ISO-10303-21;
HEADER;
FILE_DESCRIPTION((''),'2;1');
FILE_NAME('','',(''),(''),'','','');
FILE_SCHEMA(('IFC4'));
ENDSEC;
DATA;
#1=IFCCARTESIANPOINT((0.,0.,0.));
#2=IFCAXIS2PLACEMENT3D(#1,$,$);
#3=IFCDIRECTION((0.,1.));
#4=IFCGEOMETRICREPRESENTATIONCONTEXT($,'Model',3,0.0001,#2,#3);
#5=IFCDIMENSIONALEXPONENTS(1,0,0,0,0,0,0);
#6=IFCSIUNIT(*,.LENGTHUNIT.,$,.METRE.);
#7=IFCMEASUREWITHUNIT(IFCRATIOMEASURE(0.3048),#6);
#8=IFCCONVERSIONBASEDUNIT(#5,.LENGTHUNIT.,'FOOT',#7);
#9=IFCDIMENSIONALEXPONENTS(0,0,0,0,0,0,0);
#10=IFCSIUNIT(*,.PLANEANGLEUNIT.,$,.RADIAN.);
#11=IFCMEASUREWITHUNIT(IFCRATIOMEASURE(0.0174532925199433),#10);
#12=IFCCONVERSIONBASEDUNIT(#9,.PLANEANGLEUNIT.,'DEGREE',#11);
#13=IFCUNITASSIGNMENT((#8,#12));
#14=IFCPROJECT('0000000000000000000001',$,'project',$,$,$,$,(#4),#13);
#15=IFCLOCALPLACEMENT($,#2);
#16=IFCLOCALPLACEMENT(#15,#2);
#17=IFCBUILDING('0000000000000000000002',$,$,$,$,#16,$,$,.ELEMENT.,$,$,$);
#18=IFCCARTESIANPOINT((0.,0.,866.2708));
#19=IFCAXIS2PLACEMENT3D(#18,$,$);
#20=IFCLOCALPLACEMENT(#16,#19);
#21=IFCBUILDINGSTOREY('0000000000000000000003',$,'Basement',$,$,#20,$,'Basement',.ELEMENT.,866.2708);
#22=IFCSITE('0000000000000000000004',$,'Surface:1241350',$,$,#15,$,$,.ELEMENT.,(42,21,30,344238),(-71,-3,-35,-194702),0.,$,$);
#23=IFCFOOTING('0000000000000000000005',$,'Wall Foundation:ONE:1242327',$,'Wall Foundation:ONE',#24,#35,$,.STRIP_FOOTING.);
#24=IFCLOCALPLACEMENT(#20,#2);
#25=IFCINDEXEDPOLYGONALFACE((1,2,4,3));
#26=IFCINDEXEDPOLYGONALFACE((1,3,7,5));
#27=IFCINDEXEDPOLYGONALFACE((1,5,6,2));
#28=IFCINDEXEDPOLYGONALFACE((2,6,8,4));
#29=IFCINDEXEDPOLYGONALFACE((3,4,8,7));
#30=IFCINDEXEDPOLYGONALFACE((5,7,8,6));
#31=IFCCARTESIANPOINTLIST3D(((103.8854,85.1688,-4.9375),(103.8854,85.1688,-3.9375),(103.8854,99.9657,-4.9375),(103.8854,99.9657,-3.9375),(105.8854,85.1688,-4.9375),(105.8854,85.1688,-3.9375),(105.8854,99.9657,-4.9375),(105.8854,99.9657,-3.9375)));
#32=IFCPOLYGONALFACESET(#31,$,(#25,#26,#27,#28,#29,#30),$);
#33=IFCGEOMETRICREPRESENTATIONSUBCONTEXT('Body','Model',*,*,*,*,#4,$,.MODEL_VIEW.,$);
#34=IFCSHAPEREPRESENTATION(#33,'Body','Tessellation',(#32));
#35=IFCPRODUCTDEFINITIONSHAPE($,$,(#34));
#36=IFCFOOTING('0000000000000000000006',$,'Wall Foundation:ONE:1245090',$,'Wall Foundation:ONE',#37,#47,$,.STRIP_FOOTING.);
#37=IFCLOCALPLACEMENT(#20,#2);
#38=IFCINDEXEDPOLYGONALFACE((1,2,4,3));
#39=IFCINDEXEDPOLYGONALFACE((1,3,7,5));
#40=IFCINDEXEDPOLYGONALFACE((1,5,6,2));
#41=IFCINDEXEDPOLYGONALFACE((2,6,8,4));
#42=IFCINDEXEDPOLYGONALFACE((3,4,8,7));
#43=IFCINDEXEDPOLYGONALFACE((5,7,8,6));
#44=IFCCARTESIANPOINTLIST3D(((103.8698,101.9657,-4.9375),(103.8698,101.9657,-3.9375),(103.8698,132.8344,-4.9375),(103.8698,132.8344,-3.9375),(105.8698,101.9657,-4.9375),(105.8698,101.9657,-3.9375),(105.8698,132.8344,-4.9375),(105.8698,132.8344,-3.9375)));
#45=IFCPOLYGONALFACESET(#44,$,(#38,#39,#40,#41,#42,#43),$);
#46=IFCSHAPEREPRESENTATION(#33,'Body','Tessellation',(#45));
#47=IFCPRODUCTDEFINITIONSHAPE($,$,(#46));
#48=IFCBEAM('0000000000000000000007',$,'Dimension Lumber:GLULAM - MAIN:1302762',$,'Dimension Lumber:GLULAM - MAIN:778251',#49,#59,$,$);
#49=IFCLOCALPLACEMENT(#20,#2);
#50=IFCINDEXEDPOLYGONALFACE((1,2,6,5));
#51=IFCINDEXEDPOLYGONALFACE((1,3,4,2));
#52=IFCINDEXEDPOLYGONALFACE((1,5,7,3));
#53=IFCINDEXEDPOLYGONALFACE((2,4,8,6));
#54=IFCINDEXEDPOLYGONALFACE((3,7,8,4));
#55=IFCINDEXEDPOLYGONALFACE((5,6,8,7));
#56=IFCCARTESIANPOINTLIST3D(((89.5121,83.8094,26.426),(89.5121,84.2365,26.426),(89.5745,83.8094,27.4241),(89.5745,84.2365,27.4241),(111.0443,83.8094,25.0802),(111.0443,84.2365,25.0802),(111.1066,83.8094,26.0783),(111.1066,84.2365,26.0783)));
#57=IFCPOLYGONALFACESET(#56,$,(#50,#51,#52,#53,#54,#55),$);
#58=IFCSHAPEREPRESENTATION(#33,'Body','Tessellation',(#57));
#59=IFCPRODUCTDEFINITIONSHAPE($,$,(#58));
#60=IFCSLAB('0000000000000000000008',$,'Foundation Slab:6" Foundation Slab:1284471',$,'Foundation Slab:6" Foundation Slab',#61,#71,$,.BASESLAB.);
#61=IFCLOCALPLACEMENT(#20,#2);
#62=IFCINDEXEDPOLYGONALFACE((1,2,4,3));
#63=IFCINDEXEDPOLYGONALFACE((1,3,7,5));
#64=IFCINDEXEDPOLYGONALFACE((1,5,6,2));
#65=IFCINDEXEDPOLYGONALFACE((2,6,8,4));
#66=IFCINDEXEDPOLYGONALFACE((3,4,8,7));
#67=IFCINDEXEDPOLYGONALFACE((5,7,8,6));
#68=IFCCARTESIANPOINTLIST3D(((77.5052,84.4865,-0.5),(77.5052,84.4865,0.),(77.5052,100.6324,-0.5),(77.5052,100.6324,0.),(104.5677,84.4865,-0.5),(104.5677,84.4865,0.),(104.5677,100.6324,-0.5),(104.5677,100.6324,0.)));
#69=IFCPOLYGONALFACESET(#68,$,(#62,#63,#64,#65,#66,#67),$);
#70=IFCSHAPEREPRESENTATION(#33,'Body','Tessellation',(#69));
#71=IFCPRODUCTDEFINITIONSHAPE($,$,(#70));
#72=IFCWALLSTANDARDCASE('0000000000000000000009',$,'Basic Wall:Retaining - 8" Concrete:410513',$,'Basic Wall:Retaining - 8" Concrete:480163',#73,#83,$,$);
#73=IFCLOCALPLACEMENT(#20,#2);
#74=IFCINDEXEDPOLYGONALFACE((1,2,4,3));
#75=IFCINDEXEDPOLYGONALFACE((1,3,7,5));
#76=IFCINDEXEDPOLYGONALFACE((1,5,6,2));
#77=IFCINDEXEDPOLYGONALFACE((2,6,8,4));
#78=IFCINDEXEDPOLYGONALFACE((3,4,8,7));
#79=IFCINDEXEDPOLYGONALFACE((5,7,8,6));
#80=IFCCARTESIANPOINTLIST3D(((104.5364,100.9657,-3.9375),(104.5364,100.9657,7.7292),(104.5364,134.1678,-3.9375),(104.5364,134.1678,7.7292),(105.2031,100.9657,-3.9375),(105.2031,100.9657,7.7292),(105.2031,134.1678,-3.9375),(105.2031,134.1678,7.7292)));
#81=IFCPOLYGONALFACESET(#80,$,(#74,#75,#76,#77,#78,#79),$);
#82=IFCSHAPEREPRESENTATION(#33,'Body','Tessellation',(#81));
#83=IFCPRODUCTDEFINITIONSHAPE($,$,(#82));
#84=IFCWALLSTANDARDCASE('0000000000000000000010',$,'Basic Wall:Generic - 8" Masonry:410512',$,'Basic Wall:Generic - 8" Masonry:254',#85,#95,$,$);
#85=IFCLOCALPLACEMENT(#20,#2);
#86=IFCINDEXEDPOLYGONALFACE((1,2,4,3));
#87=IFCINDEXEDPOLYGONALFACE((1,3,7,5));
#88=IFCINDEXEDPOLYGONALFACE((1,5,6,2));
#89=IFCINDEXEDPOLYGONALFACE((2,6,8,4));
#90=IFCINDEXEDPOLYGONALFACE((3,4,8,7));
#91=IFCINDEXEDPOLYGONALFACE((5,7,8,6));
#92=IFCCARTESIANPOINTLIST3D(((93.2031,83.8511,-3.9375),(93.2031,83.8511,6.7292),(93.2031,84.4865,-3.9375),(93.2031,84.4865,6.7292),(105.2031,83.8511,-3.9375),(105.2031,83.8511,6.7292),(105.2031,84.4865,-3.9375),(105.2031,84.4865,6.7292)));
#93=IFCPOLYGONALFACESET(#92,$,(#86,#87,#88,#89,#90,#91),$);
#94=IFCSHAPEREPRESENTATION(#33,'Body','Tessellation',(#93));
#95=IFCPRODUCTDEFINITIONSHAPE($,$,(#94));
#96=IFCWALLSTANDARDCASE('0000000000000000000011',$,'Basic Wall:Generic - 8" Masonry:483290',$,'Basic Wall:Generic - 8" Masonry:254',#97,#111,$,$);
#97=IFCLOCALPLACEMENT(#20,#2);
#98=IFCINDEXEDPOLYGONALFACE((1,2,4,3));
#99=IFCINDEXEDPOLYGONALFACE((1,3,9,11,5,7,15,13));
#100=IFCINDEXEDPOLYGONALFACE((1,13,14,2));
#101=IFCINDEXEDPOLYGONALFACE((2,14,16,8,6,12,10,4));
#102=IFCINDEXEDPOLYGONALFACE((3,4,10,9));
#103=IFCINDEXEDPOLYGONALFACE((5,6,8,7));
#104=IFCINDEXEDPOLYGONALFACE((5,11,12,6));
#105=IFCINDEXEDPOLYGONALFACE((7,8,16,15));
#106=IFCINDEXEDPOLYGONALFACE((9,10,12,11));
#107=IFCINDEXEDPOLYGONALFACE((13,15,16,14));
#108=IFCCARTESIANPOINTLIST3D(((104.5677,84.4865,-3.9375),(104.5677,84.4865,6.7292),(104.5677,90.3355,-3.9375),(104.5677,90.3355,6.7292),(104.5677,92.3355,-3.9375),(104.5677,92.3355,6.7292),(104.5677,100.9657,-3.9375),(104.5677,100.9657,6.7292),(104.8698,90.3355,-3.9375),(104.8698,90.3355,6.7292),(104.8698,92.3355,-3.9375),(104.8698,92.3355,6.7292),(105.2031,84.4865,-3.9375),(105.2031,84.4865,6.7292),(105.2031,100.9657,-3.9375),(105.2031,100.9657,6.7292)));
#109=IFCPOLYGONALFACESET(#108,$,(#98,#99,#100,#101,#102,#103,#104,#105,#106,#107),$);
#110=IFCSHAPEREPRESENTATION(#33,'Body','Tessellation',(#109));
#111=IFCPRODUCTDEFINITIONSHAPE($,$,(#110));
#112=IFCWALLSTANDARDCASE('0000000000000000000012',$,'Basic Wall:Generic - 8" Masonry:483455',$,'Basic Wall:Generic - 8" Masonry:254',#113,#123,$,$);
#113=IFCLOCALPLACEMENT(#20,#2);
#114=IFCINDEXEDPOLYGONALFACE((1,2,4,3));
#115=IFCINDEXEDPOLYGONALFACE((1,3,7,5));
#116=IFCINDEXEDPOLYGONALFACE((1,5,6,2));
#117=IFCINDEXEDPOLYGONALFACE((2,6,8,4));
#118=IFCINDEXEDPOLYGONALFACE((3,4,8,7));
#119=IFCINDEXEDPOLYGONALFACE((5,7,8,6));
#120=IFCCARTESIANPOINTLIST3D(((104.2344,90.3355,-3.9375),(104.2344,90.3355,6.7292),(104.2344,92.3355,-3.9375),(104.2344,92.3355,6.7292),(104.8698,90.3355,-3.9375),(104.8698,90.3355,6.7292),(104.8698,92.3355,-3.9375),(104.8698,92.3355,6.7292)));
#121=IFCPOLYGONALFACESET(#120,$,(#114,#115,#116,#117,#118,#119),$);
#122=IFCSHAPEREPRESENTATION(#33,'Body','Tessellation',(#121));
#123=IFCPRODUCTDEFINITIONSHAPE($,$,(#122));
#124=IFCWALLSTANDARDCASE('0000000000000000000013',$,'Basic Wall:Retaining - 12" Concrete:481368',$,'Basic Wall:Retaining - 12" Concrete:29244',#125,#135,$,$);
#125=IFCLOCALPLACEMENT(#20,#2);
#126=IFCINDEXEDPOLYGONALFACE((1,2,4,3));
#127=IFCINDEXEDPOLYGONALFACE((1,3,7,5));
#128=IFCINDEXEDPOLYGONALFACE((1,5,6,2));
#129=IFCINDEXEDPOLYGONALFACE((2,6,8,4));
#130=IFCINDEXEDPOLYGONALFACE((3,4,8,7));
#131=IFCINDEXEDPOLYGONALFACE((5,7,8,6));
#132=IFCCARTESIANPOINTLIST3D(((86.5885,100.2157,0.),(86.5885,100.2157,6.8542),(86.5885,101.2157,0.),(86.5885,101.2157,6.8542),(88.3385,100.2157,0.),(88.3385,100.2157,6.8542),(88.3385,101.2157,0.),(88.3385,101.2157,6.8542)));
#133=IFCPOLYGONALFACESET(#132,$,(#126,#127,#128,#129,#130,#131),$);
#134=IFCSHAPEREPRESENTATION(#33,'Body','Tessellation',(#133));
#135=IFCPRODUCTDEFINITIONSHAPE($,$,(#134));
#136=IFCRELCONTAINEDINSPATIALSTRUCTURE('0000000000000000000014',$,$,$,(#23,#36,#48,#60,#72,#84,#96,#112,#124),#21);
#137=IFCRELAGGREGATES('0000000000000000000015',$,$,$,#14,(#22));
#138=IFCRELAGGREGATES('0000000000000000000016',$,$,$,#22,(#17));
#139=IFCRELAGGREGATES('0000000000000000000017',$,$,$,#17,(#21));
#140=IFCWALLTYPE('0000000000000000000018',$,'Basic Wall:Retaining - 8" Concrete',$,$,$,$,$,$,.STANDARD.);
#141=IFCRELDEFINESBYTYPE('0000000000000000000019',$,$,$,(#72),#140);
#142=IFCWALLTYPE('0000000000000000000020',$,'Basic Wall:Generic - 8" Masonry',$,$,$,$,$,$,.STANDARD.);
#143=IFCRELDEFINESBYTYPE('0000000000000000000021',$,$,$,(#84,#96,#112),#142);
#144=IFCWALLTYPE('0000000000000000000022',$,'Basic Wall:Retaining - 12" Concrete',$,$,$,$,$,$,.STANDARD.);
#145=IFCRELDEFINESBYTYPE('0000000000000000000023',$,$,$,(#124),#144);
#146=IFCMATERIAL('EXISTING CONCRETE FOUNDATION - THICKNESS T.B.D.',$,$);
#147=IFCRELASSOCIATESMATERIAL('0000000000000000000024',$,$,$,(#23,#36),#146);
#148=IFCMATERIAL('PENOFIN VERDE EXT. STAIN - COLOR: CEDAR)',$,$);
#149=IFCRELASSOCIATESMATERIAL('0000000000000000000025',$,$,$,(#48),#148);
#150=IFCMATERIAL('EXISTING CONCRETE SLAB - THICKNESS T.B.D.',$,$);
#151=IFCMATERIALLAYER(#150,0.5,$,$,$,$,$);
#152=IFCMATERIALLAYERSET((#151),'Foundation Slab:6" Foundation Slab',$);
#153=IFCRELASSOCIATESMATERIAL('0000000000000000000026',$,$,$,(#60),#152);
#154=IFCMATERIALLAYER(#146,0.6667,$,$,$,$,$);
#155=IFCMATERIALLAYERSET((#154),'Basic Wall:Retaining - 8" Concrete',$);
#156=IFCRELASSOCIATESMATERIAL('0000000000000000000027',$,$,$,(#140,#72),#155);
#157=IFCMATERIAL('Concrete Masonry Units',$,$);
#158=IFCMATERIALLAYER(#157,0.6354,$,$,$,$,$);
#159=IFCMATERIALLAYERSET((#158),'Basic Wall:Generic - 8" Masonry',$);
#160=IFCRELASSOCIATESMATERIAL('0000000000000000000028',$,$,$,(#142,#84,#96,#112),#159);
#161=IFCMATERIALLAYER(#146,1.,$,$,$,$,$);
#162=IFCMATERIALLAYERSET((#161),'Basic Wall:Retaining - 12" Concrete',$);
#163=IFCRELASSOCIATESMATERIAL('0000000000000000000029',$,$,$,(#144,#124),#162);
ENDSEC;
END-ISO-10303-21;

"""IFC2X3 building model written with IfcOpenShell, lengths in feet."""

from ifc_helpers import new_model, entity, si_unit, converted_unit, direction, frame, frame_2d, origin, place, context, subcontext, project, spatial, polyline, rectangle, extrude, clip, bounded_halfspace, material, layer, layer_set, layer_usage, type_object, element, save


model = new_model("IFC2X3")

# Units and contexts
model_context = context("Model", 3, precision=0.0001, world=origin(), true_north=direction((0.0, 1.0)))
body_context = subcontext(model_context, "Body", "Model", "MODEL_VIEW")
ifc_project = project(units=[converted_unit("LENGTHUNIT", "FOOT", entity("IfcRatioMeasure", 0.3048), si_unit("LENGTHUNIT", "METRE"), dimensions=[1, 0, 0, 0, 0, 0, 0]), converted_unit("PLANEANGLEUNIT", "DEGREE", entity("IfcRatioMeasure", 0.0174532925199433), si_unit("PLANEANGLEUNIT", "RADIAN"), dimensions=[0, 0, 0, 0, 0, 0, 0])], contexts=[model_context])

# Site, building, storey
site_placement = place(None, origin())
site = spatial("IfcSite", under=ifc_project, at=site_placement, Name="Surface:1241350", CompositionType="ELEMENT", RefLatitude=(42, 21, 30, 344238), RefLongitude=(-71, -3, -35, -194702), RefElevation=0.0)
building_placement = place(site_placement, origin())
building = spatial("IfcBuilding", under=site, at=building_placement, CompositionType="ELEMENT")
storey_placement = place(building_placement, frame((0.0, 0.0, 866.2708)))
storey = spatial("IfcBuildingStorey", under=building, at=storey_placement, Name="Basement", LongName="Basement", CompositionType="ELEMENT", Elevation=866.2708)

# Footings
ifc_material_1 = material(Name="EXISTING CONCRETE FOUNDATION - THICKNESS T.B.D.")
footing_1_placement = place(storey_placement, origin())
element("IfcFooting", 1, at=footing_1_placement, inside=storey, material=ifc_material_1, Name="Wall Foundation:ONE:1242327", ObjectType="Wall Foundation:ONE", PredefinedType="STRIP_FOOTING", context=body_context, shape_type="SweptSolid", body=[
    extrude(rectangle(XDim=14.7969, YDim=2.0, at=frame_2d((0.0, 0.0), x_axis=(1.0, 0.0))), frame((104.8854, 92.5672, -4.9375), z_axis=(0.0, 0.0, 1.0), x_axis=(0.0, -1.0, 0.0)), (0.0, 0.0, 1.0), 1.0),
])
footing_2_placement = place(storey_placement, origin())
element("IfcFooting", 2, at=footing_2_placement, inside=storey, material=ifc_material_1, Name="Wall Foundation:ONE:1245090", ObjectType="Wall Foundation:ONE", PredefinedType="STRIP_FOOTING", context=body_context, shape_type="SweptSolid", body=[
    extrude(rectangle(XDim=30.8688, YDim=2.0, at=frame_2d((0.0, 0.0), x_axis=(1.0, 0.0))), frame((104.8698, 117.4001, -4.9375), z_axis=(0.0, 0.0, 1.0), x_axis=(0.0, 1.0, 0.0)), (0.0, 0.0, 1.0), 1.0),
])

# Beam
ifc_material_2 = material(Name="PENOFIN VERDE EXT. STAIN - COLOR: CEDAR)")
beam_1_placement = place(storey_placement, frame((89.5745, 84.023, 27.4241), z_axis=(0.062378, 0.0, 0.998053), x_axis=(0.998053, 0.0, -0.062378)))
element("IfcBeam", 3, at=beam_1_placement, inside=storey, material=ifc_material_2, Name="Dimension Lumber:GLULAM - MAIN:1302762", ObjectType="Dimension Lumber:GLULAM - MAIN:778251", context=body_context, shape_type="SweptSolid", body=[
    extrude(rectangle(XDim=1.0, YDim=0.4271, at=frame_2d((0.0, 0.0), x_axis=(1.0, 0.0))), frame((0.0, 0.0, -0.5), z_axis=(1.0, 0.0, 0.0), x_axis=(0.0, 0.0, -1.0)), (0.0, 0.0, 1.0), 21.5741),
])

# Slab
ifc_material_3 = material(Name="EXISTING CONCRETE SLAB - THICKNESS T.B.D.")
ifc_layer_1 = layer(ifc_material_3, 0.5)
ifc_layer_set_1 = layer_set([ifc_layer_1], Name="Foundation Slab:6\" Foundation Slab")
ifc_layer_usage_1 = layer_usage(ifc_layer_set_1, "AXIS3", "POSITIVE", 0.0)
slab_placement = place(storey_placement, origin())
element("IfcSlab", 4, at=slab_placement, inside=storey, material=ifc_layer_usage_1, Name="Foundation Slab:6\" Foundation Slab:1284471", ObjectType="Foundation Slab:6\" Foundation Slab", PredefinedType="BASESLAB", context=body_context, shape_type="SweptSolid", body=[
    extrude(rectangle(XDim=16.1458, YDim=27.0625, at=frame_2d((0.0, 0.0), x_axis=(1.0, 0.0))), frame((91.0364, 92.5594, 0.0), z_axis=(0.0, 0.0, -1.0), x_axis=(0.0, 1.0, 0.0)), (0.0, 0.0, 1.0), 0.5),
])

# Shared definitions
ifc_layer_2 = layer(ifc_material_1, 0.6667)
ifc_layer_set_2 = layer_set([ifc_layer_2], Name="Basic Wall:Retaining - 8\" Concrete")
wall_type_1 = type_object("IfcWallType", Name="Basic Wall:Retaining - 8\" Concrete", PredefinedType="STANDARD", material=ifc_layer_set_2)

# Walls
ifc_layer_usage_2 = layer_usage(ifc_layer_set_2, "AXIS2", "NEGATIVE", 0.3333)
wall_1_placement = place(storey_placement, frame((104.8698, 134.3136, -3.9375), z_axis=(0.0, 0.0, 1.0), x_axis=(0.0, -1.0, 0.0)))
element("IfcWallStandardCase", 5, at=wall_1_placement, inside=storey, type_object=wall_type_1, material=ifc_layer_usage_2, Name="Basic Wall:Retaining - 8\" Concrete:410513", ObjectType="Basic Wall:Retaining - 8\" Concrete:480163", context=body_context, shape_type="SweptSolid", body=[
    extrude(rectangle(XDim=33.2021, YDim=0.6667, at=frame_2d((16.7469, 0.0), x_axis=(-1.0, 0.0))), origin(), (0.0, 0.0, 1.0), 11.6667),
])
ifc_material_4 = material(Name="Concrete Masonry Units")
ifc_layer_3 = layer(ifc_material_4, 0.6354)
ifc_layer_set_3 = layer_set([ifc_layer_3], Name="Basic Wall:Generic - 8\" Masonry")
ifc_layer_usage_3 = layer_usage(ifc_layer_set_3, "AXIS2", "NEGATIVE", 0.3177)
wall_type_2 = type_object("IfcWallType", Name="Basic Wall:Generic - 8\" Masonry", PredefinedType="STANDARD", material=ifc_layer_set_3)
wall_2_placement = place(storey_placement, frame((105.2031, 84.1688, -3.9375), z_axis=(0.0, 0.0, 1.0), x_axis=(-1.0, 0.0, 0.0)))
element("IfcWallStandardCase", 6, at=wall_2_placement, inside=storey, type_object=wall_type_2, material=ifc_layer_usage_3, Name="Basic Wall:Generic - 8\" Masonry:410512", ObjectType="Basic Wall:Generic - 8\" Masonry:254", context=body_context, shape_type="SweptSolid", body=[
    extrude(rectangle(XDim=12.0, YDim=0.6354, at=frame_2d((6.0, 0.0), x_axis=(-1.0, 0.0))), origin(), (0.0, 0.0, 1.0), 10.6667),
])
ifc_layer_usage_4 = layer_usage(ifc_layer_set_3, "AXIS2", "NEGATIVE", 0.3177)
wall_3_placement = place(storey_placement, frame((104.8854, 100.9657, -3.9375), z_axis=(0.0, 0.0, 1.0), x_axis=(0.0, -1.0, 0.0)))
element("IfcWallStandardCase", 7, at=wall_3_placement, inside=storey, type_object=wall_type_2, material=ifc_layer_usage_4, Name="Basic Wall:Generic - 8\" Masonry:483290", ObjectType="Basic Wall:Generic - 8\" Masonry:254", context=body_context, shape_type="Clipping", body=[
    clip(extrude(rectangle(XDim=16.4792, YDim=0.6354, at=frame_2d((8.2396, 0.0), x_axis=(-1.0, 0.0))), origin(), (0.0, 0.0, 1.0), 10.6667), bounded_halfspace(frame((8.6302, -0.0156, 10.6667), z_axis=(0.0, 1.0, 0.0), x_axis=(-1.0, 0.0, 0.0)), True, frame((8.6302, -0.0156, 10.6667), z_axis=(0.0, 1.0, 0.0), x_axis=(-1.0, 0.0, 0.0)), polyline([(0.0, 0.0), (-2.0, 0.0), (-2.0, -10.6667), (0.0, -10.6667), (0.0, 0.0)]))),
])
ifc_layer_usage_5 = layer_usage(ifc_layer_set_3, "AXIS2", "NEGATIVE", 0.3177)
wall_4_placement = place(storey_placement, frame((104.5521, 92.3355, -3.9375), z_axis=(0.0, 0.0, 1.0), x_axis=(0.0, -1.0, 0.0)))
element("IfcWallStandardCase", 8, at=wall_4_placement, inside=storey, type_object=wall_type_2, material=ifc_layer_usage_5, Name="Basic Wall:Generic - 8\" Masonry:483455", ObjectType="Basic Wall:Generic - 8\" Masonry:254", context=body_context, shape_type="SweptSolid", body=[
    extrude(rectangle(XDim=2.0, YDim=0.6354, at=frame_2d((1.0, 0.0), x_axis=(-1.0, 0.0))), origin(), (0.0, 0.0, 1.0), 10.6667),
])
ifc_layer_4 = layer(ifc_material_1, 1.0)
ifc_layer_set_4 = layer_set([ifc_layer_4], Name="Basic Wall:Retaining - 12\" Concrete")
ifc_layer_usage_6 = layer_usage(ifc_layer_set_4, "AXIS2", "POSITIVE", -0.5)
wall_type_3 = type_object("IfcWallType", Name="Basic Wall:Retaining - 12\" Concrete", PredefinedType="STANDARD", material=ifc_layer_set_4)
wall_5_placement = place(storey_placement, frame((88.3385, 100.7157, 0.0), z_axis=(0.0, 0.0, 1.0), x_axis=(-1.0, 0.0, 0.0)))
element("IfcWallStandardCase", 9, at=wall_5_placement, inside=storey, type_object=wall_type_3, material=ifc_layer_usage_6, Name="Basic Wall:Retaining - 12\" Concrete:481368", ObjectType="Basic Wall:Retaining - 12\" Concrete:29244", context=body_context, shape_type="SweptSolid", body=[
    extrude(rectangle(XDim=1.75, YDim=1.0, at=frame_2d((0.875, 0.0), x_axis=(-1.0, 0.0))), origin(), (0.0, 0.0, 1.0), 6.8542),
])

save(model, "model.ifc")
